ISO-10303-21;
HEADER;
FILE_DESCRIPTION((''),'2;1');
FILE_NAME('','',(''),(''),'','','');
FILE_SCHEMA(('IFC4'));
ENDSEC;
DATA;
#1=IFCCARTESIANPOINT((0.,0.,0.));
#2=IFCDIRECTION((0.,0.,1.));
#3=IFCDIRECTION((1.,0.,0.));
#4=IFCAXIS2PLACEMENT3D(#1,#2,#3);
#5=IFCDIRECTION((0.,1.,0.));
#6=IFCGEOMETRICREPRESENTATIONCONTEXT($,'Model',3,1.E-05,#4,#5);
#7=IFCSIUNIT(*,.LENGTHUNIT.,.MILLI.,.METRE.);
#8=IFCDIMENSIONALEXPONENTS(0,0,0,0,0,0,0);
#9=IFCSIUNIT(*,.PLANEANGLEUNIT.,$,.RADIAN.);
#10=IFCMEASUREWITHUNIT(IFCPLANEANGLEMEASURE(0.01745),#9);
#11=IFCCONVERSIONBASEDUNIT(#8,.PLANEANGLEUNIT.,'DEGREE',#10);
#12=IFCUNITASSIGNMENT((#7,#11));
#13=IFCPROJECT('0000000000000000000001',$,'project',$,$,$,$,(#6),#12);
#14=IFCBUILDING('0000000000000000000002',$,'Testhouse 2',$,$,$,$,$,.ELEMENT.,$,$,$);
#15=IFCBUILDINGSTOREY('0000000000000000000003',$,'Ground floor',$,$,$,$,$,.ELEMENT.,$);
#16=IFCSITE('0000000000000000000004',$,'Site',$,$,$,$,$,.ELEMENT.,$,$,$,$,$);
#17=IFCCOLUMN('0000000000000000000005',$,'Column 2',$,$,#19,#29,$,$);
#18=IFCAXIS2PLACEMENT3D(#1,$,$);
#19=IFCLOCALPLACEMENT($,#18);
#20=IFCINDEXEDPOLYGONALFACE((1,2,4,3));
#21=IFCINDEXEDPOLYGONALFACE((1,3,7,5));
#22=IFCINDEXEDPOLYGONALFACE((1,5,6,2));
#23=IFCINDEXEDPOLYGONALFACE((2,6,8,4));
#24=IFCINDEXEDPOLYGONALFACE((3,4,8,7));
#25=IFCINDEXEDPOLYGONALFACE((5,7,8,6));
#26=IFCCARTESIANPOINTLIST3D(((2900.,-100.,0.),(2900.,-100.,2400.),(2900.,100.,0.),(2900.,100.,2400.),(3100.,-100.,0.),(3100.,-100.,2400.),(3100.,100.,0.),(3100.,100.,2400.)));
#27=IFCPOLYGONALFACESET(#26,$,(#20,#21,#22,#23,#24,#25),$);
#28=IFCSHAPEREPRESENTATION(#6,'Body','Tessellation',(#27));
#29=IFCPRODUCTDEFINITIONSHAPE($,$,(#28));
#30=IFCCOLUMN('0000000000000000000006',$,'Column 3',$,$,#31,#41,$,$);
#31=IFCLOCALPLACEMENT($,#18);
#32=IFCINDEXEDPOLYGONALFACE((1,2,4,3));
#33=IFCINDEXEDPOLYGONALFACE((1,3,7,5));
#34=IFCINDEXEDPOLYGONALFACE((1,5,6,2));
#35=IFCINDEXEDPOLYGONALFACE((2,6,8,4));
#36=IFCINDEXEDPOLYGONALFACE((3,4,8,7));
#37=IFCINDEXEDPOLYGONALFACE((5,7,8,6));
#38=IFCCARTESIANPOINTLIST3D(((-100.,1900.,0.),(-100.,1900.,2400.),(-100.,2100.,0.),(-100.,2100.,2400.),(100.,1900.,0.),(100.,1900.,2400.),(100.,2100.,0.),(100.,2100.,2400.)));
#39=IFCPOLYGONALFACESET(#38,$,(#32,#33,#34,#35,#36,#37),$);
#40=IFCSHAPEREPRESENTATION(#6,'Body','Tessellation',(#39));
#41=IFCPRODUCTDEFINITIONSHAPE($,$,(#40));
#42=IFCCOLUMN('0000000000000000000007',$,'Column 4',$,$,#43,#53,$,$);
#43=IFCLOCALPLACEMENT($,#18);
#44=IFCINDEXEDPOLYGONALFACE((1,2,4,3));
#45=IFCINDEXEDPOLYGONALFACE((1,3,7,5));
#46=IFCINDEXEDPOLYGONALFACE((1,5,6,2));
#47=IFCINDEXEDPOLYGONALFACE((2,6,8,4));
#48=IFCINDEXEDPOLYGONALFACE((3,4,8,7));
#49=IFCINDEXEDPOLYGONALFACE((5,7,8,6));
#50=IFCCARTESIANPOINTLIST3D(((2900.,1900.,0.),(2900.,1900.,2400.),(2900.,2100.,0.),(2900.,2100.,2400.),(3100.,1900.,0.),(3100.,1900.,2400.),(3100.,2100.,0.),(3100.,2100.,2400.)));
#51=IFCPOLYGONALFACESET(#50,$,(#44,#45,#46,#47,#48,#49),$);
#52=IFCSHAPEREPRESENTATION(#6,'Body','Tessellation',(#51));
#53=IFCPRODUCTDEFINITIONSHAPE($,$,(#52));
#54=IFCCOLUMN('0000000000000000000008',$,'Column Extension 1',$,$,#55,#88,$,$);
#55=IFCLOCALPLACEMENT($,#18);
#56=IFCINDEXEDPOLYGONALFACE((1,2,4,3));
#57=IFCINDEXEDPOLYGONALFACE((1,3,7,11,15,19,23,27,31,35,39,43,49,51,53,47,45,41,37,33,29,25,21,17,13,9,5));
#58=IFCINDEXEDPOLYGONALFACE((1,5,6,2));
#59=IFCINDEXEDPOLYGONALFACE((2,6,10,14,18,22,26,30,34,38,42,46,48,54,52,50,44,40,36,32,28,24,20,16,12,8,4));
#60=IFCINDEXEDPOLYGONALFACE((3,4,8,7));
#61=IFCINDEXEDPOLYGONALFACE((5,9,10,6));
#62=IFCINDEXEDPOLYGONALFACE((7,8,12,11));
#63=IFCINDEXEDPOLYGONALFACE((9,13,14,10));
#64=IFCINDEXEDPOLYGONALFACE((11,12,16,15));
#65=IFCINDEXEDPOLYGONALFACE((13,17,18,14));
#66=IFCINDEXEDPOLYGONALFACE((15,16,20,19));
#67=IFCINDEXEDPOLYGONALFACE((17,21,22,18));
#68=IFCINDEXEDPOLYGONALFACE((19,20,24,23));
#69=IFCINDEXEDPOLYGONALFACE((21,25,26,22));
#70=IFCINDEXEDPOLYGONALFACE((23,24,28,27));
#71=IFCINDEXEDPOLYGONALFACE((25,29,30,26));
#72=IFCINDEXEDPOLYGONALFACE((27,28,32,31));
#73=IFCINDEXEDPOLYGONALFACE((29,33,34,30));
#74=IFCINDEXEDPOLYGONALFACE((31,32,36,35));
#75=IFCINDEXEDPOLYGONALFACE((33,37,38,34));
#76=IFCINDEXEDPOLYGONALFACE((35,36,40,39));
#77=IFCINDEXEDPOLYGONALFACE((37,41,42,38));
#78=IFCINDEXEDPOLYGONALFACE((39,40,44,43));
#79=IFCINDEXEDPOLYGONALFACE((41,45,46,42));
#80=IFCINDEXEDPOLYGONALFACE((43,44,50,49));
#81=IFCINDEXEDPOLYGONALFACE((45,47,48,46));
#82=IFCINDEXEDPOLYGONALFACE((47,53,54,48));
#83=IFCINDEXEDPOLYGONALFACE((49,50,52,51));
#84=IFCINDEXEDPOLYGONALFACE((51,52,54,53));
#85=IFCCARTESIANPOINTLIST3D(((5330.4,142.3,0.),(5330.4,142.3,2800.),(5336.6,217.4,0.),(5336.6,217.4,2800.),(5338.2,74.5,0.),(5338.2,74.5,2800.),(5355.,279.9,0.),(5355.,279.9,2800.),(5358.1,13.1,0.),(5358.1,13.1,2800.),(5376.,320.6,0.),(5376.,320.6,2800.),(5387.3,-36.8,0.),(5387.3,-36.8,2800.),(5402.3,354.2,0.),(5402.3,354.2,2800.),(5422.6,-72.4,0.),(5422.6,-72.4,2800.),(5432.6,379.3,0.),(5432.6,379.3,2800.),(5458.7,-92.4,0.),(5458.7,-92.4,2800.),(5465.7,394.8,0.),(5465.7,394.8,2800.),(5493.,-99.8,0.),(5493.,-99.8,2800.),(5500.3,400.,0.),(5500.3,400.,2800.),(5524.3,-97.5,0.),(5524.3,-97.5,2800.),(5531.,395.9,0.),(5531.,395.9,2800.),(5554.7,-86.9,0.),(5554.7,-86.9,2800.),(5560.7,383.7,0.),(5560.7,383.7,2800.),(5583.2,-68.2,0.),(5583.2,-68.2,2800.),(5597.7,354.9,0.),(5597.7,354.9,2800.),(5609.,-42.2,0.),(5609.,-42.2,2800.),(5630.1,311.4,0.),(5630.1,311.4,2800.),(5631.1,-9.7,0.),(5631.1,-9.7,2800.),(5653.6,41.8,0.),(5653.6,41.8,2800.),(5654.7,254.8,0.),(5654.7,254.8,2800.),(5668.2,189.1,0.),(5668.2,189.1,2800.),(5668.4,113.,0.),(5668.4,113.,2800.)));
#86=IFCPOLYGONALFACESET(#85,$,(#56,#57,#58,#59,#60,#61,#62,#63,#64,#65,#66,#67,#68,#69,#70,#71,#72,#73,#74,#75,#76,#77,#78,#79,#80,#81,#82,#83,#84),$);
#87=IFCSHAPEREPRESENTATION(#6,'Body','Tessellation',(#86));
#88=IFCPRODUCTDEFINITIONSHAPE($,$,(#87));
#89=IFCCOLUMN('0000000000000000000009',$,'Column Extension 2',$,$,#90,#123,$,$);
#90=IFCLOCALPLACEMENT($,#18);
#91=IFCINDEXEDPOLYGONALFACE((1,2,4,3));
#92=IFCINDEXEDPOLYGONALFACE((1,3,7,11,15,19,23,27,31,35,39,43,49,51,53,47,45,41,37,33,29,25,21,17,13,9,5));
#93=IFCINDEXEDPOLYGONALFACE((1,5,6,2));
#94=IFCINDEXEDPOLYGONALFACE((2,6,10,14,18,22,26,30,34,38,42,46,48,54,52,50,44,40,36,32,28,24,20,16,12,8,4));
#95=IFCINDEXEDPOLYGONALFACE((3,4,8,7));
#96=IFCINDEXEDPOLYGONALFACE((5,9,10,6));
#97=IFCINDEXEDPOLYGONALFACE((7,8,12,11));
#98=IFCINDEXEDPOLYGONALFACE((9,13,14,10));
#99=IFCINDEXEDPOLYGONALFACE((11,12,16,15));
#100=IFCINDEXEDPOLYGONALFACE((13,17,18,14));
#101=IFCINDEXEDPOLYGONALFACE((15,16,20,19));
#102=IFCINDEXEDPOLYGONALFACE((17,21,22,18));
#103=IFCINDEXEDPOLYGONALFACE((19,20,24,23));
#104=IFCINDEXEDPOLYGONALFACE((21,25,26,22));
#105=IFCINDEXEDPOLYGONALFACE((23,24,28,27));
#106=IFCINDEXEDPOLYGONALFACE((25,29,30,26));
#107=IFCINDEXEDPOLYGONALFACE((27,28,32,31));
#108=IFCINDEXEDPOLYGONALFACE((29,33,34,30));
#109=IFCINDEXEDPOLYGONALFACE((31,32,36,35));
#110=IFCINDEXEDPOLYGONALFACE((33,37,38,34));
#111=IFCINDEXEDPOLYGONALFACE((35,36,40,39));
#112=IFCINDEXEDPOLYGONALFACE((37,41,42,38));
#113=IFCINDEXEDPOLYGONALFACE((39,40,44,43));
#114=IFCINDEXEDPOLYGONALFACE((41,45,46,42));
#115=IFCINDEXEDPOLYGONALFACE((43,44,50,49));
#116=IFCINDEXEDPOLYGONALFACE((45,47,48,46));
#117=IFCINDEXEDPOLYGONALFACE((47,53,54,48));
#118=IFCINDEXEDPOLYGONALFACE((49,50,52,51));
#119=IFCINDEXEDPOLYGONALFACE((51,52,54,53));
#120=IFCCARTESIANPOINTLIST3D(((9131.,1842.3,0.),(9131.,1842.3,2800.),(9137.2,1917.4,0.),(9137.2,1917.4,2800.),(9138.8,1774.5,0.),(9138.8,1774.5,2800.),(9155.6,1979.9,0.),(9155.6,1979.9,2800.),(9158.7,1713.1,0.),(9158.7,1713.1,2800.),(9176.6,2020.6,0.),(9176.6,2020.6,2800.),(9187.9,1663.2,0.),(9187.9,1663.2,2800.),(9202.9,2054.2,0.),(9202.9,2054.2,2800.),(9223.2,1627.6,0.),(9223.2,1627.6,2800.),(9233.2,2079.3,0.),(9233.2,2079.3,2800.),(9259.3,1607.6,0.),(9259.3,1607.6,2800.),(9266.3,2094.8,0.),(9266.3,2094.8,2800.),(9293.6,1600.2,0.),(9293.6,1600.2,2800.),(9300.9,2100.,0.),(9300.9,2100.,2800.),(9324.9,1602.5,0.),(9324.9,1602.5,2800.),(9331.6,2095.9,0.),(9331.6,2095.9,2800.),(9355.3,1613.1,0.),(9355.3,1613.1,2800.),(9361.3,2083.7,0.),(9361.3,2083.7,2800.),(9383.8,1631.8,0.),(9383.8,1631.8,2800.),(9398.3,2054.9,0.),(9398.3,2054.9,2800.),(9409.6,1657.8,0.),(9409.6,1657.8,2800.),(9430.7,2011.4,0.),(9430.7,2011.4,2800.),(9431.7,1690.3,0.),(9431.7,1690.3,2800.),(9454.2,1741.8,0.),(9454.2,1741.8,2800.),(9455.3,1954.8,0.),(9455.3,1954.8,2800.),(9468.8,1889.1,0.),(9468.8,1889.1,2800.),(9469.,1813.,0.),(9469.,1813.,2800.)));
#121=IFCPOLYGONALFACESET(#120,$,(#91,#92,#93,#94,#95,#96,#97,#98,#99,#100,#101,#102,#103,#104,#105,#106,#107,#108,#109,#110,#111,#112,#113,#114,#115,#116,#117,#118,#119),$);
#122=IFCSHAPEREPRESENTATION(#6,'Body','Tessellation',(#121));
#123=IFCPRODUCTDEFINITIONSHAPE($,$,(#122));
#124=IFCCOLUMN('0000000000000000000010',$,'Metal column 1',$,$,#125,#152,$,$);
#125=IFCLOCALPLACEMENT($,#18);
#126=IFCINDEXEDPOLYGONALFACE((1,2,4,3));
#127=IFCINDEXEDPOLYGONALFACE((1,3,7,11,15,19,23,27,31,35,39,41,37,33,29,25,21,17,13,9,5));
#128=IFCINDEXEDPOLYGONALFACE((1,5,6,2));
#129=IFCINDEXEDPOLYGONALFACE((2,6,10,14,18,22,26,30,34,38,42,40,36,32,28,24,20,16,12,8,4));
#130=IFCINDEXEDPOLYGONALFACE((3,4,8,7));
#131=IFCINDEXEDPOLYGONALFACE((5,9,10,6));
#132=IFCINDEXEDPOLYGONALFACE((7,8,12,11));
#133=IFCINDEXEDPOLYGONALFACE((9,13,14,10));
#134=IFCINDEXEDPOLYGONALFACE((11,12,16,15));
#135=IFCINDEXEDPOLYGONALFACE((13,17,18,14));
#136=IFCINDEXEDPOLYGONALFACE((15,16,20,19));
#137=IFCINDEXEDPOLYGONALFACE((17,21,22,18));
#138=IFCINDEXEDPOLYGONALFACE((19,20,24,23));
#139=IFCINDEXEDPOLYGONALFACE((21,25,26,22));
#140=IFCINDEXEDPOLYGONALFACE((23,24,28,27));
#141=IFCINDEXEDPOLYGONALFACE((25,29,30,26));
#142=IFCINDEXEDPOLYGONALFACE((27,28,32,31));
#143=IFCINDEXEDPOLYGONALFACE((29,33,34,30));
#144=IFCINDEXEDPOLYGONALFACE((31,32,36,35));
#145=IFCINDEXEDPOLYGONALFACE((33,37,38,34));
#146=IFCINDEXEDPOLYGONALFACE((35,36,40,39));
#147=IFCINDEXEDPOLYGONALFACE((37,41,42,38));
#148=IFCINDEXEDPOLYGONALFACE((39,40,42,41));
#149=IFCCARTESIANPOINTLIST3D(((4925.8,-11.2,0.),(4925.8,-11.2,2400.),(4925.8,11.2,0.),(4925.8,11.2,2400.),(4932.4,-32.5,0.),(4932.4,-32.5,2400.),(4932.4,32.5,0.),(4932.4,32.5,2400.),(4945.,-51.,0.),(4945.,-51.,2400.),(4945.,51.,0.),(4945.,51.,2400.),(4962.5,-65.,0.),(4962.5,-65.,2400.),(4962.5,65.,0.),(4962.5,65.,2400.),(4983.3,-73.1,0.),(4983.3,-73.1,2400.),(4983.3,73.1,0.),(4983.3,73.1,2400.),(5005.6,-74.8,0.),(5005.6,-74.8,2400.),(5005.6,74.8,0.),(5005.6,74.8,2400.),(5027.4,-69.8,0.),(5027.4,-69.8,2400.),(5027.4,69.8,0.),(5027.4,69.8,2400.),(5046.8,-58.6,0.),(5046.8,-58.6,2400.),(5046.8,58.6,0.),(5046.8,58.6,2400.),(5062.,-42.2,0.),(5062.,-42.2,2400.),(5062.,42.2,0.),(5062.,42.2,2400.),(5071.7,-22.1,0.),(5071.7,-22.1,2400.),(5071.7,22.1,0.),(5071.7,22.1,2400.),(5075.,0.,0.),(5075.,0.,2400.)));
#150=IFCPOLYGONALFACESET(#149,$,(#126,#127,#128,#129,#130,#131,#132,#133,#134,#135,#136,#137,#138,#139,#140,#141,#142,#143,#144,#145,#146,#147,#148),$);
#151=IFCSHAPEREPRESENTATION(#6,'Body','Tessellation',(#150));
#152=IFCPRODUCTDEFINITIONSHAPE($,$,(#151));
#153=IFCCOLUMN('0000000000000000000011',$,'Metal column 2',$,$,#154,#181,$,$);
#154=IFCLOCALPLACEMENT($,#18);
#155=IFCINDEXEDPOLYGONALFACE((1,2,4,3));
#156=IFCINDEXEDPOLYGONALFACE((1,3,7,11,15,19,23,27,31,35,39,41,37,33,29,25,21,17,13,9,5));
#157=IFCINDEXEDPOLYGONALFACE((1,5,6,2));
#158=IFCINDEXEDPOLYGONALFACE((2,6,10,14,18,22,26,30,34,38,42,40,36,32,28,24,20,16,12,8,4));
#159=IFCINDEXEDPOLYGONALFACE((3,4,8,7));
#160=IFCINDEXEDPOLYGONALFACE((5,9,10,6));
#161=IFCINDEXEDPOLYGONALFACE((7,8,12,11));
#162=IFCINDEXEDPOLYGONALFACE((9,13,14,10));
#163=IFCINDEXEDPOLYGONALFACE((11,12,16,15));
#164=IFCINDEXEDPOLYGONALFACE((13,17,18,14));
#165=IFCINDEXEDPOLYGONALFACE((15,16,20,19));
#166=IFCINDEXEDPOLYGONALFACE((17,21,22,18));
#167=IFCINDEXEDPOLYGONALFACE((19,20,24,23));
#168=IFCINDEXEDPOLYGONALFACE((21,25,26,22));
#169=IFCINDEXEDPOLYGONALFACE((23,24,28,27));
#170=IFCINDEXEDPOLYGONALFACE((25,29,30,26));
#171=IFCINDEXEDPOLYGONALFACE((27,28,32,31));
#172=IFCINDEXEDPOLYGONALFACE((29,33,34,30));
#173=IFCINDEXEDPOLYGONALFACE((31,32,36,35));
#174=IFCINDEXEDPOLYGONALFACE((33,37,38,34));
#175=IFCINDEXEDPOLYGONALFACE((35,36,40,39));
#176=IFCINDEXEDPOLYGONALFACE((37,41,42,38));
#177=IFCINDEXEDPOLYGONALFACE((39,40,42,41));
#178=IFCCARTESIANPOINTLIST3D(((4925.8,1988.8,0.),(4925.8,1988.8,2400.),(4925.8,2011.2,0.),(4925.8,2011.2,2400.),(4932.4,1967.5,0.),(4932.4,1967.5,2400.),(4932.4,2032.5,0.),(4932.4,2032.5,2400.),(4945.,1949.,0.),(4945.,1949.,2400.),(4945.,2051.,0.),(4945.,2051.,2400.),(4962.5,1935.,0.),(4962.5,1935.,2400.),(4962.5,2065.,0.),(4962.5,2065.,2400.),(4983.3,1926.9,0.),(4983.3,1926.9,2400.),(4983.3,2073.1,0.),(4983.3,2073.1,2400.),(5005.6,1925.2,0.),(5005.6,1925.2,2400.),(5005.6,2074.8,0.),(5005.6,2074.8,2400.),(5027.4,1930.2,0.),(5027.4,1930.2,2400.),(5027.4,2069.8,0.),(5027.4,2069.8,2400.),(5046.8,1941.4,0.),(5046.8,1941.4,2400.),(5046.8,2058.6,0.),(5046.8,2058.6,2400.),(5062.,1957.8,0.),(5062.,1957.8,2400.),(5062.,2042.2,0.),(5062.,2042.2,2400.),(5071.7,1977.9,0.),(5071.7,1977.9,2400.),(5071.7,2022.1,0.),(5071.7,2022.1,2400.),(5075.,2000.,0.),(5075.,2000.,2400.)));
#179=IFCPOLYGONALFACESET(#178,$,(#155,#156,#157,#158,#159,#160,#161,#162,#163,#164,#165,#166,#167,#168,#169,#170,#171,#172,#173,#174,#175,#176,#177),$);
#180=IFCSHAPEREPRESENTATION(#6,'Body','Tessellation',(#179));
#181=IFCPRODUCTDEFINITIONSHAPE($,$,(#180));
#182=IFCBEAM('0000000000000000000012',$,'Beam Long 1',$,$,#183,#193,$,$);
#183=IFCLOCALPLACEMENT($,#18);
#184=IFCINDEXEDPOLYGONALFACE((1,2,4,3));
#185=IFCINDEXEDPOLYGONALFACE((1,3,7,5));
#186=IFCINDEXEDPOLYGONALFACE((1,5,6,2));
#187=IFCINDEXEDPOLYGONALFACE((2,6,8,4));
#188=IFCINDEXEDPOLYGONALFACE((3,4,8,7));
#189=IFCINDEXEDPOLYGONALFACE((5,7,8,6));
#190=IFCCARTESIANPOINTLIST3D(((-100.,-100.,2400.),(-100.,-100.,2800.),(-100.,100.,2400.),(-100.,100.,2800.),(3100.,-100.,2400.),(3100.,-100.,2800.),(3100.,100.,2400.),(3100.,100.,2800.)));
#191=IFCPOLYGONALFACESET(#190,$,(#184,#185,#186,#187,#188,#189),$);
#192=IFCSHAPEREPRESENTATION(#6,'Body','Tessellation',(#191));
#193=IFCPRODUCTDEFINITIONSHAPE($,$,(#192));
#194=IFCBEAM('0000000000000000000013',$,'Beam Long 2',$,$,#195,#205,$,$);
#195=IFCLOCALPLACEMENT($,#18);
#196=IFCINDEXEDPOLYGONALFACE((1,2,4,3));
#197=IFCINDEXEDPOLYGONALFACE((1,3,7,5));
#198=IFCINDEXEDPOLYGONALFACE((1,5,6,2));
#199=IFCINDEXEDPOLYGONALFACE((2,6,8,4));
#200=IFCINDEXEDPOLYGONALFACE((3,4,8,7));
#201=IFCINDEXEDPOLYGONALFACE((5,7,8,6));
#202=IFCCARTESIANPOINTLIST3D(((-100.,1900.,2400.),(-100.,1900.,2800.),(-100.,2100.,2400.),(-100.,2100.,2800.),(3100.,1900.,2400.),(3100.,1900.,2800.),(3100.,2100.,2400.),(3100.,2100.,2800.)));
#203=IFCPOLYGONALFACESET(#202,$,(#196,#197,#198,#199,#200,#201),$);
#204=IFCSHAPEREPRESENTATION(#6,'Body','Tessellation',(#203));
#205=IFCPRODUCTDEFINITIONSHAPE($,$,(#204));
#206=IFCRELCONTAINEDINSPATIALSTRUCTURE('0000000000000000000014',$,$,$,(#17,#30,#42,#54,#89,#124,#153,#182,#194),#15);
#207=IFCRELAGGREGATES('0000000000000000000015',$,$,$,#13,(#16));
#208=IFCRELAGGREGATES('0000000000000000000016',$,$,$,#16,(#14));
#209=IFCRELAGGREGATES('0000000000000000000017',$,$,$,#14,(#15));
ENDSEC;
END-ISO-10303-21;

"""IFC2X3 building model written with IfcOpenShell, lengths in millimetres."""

from ifc_helpers import new_model, entity, si_unit, converted_unit, direction, frame, origin_with_axes, origin_2d_with_axis, place, context, project, spatial, polyline, circle, ellipse, outline, extrude, element, save


model = new_model("IFC2X3")

# Units and contexts
model_context = context("Model", 3, precision=1e-05, world=origin_with_axes(), true_north=direction((0.0, 1.0, 0.0)))
ifc_project = project(units=[si_unit("LENGTHUNIT", "METRE", prefix="MILLI"), converted_unit("PLANEANGLEUNIT", "DEGREE", entity("IfcPlaneAngleMeasure", 0.01745), si_unit("PLANEANGLEUNIT", "RADIAN"), dimensions=[0, 0, 0, 0, 0, 0, 0])], contexts=[model_context])

# Site, building, storey
site = spatial("IfcSite", under=ifc_project, Name="Site", CompositionType="ELEMENT")
building = spatial("IfcBuilding", under=site, Name="Testhouse 2", CompositionType="ELEMENT")
storey = spatial("IfcBuildingStorey", under=building, Name="Ground floor", CompositionType="ELEMENT")

# Columns
column_1_placement = place(None, origin_with_axes())
element("IfcColumn", 1, at=column_1_placement, inside=storey, Name="Column 2", context=model_context, shape_type="SweptSolid", body=[
    extrude(outline(polyline([(-100.0, -100.0), (100.0, -100.0), (100.0, 100.0), (-100.0, 100.0), (-100.0, -100.0)])), frame((3000.0, 0.0, 0.0), z_axis=(0.0, 0.0, 1.0), x_axis=(1.0, 0.0, 0.0)), (0.0, 0.0, 1.0), 2400.0),
])
column_2_placement = place(None, origin_with_axes())
element("IfcColumn", 2, at=column_2_placement, inside=storey, Name="Column 3", context=model_context, shape_type="SweptSolid", body=[
    extrude(outline(polyline([(-100.0, -100.0), (100.0, -100.0), (100.0, 100.0), (-100.0, 100.0), (-100.0, -100.0)])), frame((0.0, 2000.0, 0.0), z_axis=(0.0, 0.0, 1.0), x_axis=(1.0, 0.0, 0.0)), (0.0, 0.0, 1.0), 2400.0),
])
column_3_placement = place(None, origin_with_axes())
element("IfcColumn", 3, at=column_3_placement, inside=storey, Name="Column 4", context=model_context, shape_type="SweptSolid", body=[
    extrude(outline(polyline([(-100.0, -100.0), (100.0, -100.0), (100.0, 100.0), (-100.0, 100.0), (-100.0, -100.0)])), frame((3000.0, 2000.0, 0.0), z_axis=(0.0, 0.0, 1.0), x_axis=(1.0, 0.0, 0.0)), (0.0, 0.0, 1.0), 2400.0),
])
column_4_placement = place(None, origin_with_axes())
element("IfcColumn", 4, at=column_4_placement, inside=storey, Name="Column Extension 1", context=model_context, shape_type="SweptSolid", body=[
    extrude(ellipse(SemiAxis1=250.0, SemiAxis2=170.0, at=origin_2d_with_axis()), frame((5500.3, 150.0, 0.0), z_axis=(0.0, 0.0, 1.0), x_axis=(0.0, 1.0, 0.0)), (0.0, 0.0, 1.0), 2800.0),
])
column_5_placement = place(None, origin_with_axes())
element("IfcColumn", 5, at=column_5_placement, inside=storey, Name="Column Extension 2", context=model_context, shape_type="SweptSolid", body=[
    extrude(ellipse(SemiAxis1=250.0, SemiAxis2=170.0, at=origin_2d_with_axis()), frame((9300.9, 1850.0, 0.0), z_axis=(0.0, 0.0, 1.0), x_axis=(0.0, 1.0, 0.0)), (0.0, 0.0, 1.0), 2800.0),
])
column_6_placement = place(None, origin_with_axes())
element("IfcColumn", 6, at=column_6_placement, inside=storey, Name="Metal column 1", context=model_context, shape_type="SweptSolid", body=[
    extrude(circle(Radius=75.0, at=origin_2d_with_axis()), frame((5000.0, 0.0, 0.0), z_axis=(0.0, 0.0, 1.0), x_axis=(1.0, 0.0, 0.0)), (0.0, 0.0, 1.0), 2400.0),
])
column_7_placement = place(None, origin_with_axes())
element("IfcColumn", 7, at=column_7_placement, inside=storey, Name="Metal column 2", context=model_context, shape_type="SweptSolid", body=[
    extrude(circle(Radius=75.0, at=origin_2d_with_axis()), frame((5000.0, 2000.0, 0.0), z_axis=(0.0, 0.0, 1.0), x_axis=(1.0, 0.0, 0.0)), (0.0, 0.0, 1.0), 2400.0),
])

# Beams
beam_1_placement = place(None, origin_with_axes())
element("IfcBeam", 8, at=beam_1_placement, inside=storey, Name="Beam Long 1", context=model_context, shape_type="SweptSolid", body=[
    extrude(outline(polyline([(-200.0, -100.0), (200.0, -100.0), (200.0, 100.0), (-200.0, 100.0), (-200.0, -100.0)])), frame((-100.0, 0.0, 2600.0), z_axis=(1.0, 0.0, 0.0), x_axis=(0.0, 0.0, -1.0)), (0.0, 0.0, 1.0), 3200.0),
])
beam_2_placement = place(None, origin_with_axes())
element("IfcBeam", 9, at=beam_2_placement, inside=storey, Name="Beam Long 2", context=model_context, shape_type="SweptSolid", body=[
    extrude(outline(polyline([(-200.0, -100.0), (200.0, -100.0), (200.0, 100.0), (-200.0, 100.0), (-200.0, -100.0)])), frame((-100.0, 2000.0, 2600.0), z_axis=(1.0, 0.0, 0.0), x_axis=(0.0, 0.0, -1.0)), (0.0, 0.0, 1.0), 3200.0),
])

save(model, "model.ifc")
